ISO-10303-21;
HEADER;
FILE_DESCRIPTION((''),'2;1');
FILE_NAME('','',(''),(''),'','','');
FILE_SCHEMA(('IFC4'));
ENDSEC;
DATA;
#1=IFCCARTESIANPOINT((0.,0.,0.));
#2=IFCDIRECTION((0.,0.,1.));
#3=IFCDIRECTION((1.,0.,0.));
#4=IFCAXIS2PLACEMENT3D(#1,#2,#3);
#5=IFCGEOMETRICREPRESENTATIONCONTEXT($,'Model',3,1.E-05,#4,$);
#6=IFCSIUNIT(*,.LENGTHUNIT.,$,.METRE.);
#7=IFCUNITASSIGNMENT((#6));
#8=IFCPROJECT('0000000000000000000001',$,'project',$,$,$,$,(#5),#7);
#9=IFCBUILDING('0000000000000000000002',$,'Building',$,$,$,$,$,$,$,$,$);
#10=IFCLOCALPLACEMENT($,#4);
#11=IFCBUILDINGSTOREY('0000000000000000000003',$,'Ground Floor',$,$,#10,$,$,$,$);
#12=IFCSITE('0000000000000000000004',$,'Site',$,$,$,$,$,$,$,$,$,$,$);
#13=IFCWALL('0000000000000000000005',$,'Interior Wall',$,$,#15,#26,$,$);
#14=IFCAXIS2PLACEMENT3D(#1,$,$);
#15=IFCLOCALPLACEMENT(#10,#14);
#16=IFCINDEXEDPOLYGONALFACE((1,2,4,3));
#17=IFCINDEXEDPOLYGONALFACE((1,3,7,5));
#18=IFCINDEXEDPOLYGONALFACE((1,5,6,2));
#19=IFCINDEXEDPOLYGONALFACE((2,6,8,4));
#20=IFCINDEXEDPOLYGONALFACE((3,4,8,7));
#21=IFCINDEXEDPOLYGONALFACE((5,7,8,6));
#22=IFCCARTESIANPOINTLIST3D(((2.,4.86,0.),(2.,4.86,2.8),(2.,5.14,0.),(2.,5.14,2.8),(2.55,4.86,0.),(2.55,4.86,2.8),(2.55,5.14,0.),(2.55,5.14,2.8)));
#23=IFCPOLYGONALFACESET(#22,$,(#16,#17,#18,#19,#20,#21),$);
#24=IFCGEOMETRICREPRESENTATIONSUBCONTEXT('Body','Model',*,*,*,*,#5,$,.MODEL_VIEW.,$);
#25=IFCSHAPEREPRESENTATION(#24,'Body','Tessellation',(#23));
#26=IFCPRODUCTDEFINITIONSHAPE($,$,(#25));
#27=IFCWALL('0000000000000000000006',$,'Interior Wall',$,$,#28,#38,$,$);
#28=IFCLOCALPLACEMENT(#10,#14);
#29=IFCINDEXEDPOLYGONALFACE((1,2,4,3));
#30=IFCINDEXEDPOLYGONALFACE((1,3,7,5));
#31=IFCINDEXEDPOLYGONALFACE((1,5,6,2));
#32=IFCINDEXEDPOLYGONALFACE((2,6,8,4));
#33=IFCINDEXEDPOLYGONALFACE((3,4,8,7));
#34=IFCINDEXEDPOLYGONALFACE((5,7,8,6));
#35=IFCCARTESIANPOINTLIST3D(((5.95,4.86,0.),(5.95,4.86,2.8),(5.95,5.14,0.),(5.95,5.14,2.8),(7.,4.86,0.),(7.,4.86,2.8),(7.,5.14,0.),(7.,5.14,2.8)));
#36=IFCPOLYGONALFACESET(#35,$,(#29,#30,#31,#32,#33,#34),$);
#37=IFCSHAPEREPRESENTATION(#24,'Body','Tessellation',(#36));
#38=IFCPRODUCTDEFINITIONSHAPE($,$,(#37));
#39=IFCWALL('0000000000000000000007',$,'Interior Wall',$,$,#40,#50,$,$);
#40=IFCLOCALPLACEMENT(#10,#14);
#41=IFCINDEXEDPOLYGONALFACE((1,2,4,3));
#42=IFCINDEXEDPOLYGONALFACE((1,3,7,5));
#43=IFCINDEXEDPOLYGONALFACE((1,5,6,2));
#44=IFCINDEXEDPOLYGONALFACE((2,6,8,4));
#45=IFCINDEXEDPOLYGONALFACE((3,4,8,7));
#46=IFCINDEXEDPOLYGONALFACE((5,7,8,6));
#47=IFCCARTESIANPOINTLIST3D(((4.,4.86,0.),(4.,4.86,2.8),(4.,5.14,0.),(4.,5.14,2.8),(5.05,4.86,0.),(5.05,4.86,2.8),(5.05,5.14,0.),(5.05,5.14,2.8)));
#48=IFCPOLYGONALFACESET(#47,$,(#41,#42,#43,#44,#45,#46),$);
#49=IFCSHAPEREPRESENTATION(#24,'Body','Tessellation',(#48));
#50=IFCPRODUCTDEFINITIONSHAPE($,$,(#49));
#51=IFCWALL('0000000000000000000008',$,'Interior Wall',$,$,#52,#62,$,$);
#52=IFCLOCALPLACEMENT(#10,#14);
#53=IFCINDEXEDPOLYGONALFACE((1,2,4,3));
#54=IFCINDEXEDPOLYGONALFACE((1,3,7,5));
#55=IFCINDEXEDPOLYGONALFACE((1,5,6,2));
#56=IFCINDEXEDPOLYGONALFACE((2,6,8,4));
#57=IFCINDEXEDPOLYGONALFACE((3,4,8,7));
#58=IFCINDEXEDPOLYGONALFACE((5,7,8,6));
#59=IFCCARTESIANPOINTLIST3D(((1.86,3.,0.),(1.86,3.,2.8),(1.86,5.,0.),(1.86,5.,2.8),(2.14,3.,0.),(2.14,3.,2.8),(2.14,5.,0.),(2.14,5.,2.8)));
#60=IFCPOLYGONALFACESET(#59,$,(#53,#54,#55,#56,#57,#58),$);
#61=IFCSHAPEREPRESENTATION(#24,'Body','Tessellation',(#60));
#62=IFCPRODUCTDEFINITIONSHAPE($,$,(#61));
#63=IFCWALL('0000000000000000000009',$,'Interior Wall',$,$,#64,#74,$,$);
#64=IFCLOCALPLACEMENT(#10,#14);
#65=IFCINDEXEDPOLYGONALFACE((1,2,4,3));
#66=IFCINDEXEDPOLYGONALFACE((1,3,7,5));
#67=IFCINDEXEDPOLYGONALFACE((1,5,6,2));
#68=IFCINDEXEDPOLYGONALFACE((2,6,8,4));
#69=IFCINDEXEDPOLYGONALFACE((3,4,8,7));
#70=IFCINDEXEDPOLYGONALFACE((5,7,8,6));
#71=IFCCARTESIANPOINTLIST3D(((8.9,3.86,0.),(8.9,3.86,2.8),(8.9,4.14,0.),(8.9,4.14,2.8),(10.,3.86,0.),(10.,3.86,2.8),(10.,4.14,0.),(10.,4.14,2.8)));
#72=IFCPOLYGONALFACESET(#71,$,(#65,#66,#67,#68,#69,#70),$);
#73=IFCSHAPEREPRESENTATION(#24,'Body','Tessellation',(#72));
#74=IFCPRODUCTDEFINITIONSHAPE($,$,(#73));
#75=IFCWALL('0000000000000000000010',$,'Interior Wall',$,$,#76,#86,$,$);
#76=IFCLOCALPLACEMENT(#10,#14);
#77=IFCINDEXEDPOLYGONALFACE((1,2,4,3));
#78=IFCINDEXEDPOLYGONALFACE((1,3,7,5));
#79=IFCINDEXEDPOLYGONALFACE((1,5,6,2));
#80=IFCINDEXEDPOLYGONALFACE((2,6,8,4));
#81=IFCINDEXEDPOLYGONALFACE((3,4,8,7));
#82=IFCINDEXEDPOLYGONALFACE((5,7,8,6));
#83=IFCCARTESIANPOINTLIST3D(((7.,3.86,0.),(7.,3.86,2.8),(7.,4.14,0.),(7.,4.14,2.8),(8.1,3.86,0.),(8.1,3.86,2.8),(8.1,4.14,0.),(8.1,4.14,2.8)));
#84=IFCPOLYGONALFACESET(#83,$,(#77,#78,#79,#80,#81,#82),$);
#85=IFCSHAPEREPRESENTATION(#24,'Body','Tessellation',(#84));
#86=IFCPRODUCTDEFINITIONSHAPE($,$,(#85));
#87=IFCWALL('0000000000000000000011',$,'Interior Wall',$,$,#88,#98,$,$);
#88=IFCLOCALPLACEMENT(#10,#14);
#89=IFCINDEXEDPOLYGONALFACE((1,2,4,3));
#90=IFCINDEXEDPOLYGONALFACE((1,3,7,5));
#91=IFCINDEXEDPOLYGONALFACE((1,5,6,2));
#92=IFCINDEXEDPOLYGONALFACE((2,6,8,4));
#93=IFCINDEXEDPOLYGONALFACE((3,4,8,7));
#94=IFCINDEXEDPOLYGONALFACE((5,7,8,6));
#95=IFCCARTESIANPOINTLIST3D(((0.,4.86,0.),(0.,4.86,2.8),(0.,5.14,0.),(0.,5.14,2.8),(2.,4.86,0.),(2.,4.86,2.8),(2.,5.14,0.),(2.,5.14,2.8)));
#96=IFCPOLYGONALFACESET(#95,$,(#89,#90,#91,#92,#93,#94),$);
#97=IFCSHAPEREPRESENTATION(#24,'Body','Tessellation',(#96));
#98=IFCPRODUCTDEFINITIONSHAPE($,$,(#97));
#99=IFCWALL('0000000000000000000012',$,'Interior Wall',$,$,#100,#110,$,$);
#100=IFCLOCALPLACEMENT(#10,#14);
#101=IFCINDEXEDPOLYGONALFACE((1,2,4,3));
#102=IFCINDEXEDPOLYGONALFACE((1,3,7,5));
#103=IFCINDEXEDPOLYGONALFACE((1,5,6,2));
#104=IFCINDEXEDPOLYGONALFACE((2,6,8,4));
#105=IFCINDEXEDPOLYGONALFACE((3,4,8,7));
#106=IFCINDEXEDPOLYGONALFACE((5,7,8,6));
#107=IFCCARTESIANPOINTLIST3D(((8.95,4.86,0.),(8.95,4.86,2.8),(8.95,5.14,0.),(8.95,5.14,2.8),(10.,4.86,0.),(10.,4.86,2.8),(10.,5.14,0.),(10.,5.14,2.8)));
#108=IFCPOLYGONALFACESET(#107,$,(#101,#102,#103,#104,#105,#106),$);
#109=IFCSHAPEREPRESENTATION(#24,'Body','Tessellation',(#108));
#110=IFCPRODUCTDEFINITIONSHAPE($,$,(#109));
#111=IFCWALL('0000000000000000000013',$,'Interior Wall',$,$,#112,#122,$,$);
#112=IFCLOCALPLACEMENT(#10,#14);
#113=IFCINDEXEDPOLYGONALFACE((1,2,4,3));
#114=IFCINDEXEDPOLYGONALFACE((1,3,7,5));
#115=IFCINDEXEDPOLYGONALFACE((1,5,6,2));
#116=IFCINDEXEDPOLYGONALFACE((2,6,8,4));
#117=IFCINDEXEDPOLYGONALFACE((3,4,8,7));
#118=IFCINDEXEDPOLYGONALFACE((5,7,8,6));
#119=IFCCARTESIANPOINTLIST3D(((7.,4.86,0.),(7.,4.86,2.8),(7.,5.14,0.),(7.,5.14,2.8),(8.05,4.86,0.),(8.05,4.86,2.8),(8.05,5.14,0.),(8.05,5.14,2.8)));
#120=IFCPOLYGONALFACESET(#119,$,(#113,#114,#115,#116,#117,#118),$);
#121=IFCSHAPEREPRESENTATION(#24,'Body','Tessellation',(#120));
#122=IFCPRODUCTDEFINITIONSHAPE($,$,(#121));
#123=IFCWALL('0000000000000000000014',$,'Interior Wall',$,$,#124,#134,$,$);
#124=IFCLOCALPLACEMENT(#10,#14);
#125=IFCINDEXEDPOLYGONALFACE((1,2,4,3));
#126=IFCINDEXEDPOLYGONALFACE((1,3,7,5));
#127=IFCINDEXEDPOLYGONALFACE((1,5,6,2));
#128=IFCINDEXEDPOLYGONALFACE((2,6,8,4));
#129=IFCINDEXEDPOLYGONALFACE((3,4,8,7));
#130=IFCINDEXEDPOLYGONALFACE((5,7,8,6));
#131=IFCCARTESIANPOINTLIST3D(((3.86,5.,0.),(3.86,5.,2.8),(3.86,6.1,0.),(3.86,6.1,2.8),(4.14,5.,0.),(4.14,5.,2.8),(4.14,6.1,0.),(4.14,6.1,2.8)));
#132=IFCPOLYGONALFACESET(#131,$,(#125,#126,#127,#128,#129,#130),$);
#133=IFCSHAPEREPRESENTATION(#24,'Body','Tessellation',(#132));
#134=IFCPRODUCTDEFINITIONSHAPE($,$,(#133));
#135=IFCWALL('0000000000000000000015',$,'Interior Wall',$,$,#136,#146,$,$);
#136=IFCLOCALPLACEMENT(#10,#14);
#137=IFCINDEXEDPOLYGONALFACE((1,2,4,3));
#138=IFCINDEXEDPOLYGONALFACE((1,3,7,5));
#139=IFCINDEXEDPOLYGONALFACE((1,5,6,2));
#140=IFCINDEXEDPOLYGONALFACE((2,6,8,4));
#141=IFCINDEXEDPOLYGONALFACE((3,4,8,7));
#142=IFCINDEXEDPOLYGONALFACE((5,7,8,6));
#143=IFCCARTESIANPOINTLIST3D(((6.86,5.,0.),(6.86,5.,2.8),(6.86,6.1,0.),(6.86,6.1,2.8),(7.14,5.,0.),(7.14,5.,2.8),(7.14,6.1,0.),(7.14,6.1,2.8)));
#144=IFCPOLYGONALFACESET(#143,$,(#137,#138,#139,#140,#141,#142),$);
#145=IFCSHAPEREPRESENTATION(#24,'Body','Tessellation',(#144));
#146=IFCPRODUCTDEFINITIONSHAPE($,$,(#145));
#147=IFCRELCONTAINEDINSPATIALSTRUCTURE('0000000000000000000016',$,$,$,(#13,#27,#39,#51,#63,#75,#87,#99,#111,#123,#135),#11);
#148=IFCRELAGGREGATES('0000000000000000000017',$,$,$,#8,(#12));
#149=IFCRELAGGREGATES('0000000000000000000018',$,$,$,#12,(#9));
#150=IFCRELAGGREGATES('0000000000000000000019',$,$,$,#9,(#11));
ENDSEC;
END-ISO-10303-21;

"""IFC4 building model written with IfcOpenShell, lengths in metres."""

from ifc_helpers import new_model, si_unit, frame, origin_with_axes, place, context, subcontext, project, spatial, indexed_curve, outline, extrude, element, save


model = new_model("IFC4")

# Units and contexts
model_context = context("Model", 3, precision=1e-05, world=origin_with_axes())
body_context = subcontext(model_context, "Body", "Model", "MODEL_VIEW")
ifc_project = project(units=[si_unit("LENGTHUNIT", "METRE")], contexts=[model_context])

# Site, building, storey
site = spatial("IfcSite", under=ifc_project, Name="Site")
building = spatial("IfcBuilding", under=site, Name="Building")
storey_placement = place(None, origin_with_axes())
storey = spatial("IfcBuildingStorey", under=building, at=storey_placement, Name="Ground Floor")

# Walls
for number, where, z_axis, x_axis, name in (
    (1, (2.55, 5.0, 0.0), (0.0, 0.0, 1.0), (-1.0, 0.0, 0.0), "Interior Wall"),
):
    element("IfcWall", number, at=place(storey_placement, frame(where, z_axis=z_axis, x_axis=x_axis)), inside=storey, Name=name, context=body_context, shape_type="SweptSolid", body=[
        extrude(outline(indexed_curve([(0.0, 0.0), (0.0, 0.28), (0.55, 0.28), (0.55, 0.0), (0.0, 0.0)], self_intersect=False)), frame((0.0, -0.14, 0.0), z_axis=(0.0, 0.0, 1.0), x_axis=(1.0, 0.0, 0.0)), (0.0, 0.0, 1.0), 2.8),
    ])
for number, where, z_axis, x_axis, name in (
    (2, (7.0, 5.0, 0.0), (0.0, 0.0, 1.0), (-1.0, 0.0, 0.0), "Interior Wall"),
    (3, (5.05, 5.0, 0.0), (0.0, 0.0, 1.0), (-1.0, 0.0, 0.0), "Interior Wall"),
):
    element("IfcWall", number, at=place(storey_placement, frame(where, z_axis=z_axis, x_axis=x_axis)), inside=storey, Name=name, context=body_context, shape_type="SweptSolid", body=[
        extrude(outline(indexed_curve([(0.0, 0.0), (0.0, 0.28), (1.05, 0.28), (1.05, 0.0), (0.0, 0.0)], self_intersect=False)), frame((0.0, -0.14, 0.0), z_axis=(0.0, 0.0, 1.0), x_axis=(1.0, 0.0, 0.0)), (0.0, 0.0, 1.0), 2.8),
    ])
wall_1_placement = place(storey_placement, frame((2.0, 5.0, 0.0), z_axis=(0.0, 0.0, 1.0), x_axis=(0.0, -1.0, 0.0)))
element("IfcWall", 4, at=wall_1_placement, inside=storey, Name="Interior Wall", context=body_context, shape_type="SweptSolid", body=[
    extrude(outline(indexed_curve([(0.0, 0.0), (0.0, 0.28), (2.0, 0.28), (2.0, 0.0), (0.0, 0.0)], self_intersect=False)), frame((0.0, -0.14, 0.0), z_axis=(0.0, 0.0, 1.0), x_axis=(1.0, 0.0, 0.0)), (0.0, 0.0, 1.0), 2.8),
])
for number, where, z_axis, x_axis, name in (
    (5, (10.0, 4.0, 0.0), (0.0, 0.0, 1.0), (-1.0, 0.0, 0.0), "Interior Wall"),
    (6, (8.1, 4.0, 0.0), (0.0, 0.0, 1.0), (-1.0, 0.0, 0.0), "Interior Wall"),
):
    element("IfcWall", number, at=place(storey_placement, frame(where, z_axis=z_axis, x_axis=x_axis)), inside=storey, Name=name, context=body_context, shape_type="SweptSolid", body=[
        extrude(outline(indexed_curve([(0.0, 0.0), (0.0, 0.28), (1.1, 0.28), (1.1, 0.0), (0.0, 0.0)], self_intersect=False)), frame((0.0, -0.14, 0.0), z_axis=(0.0, 0.0, 1.0), x_axis=(1.0, 0.0, 0.0)), (0.0, 0.0, 1.0), 2.8),
    ])
wall_2_placement = place(storey_placement, frame((2.0, 5.0, 0.0), z_axis=(0.0, 0.0, 1.0), x_axis=(-1.0, 0.0, 0.0)))
element("IfcWall", 7, at=wall_2_placement, inside=storey, Name="Interior Wall", context=body_context, shape_type="SweptSolid", body=[
    extrude(outline(indexed_curve([(0.0, 0.0), (0.0, 0.28), (2.0, 0.28), (2.0, 0.0), (0.0, 0.0)], self_intersect=False)), frame((0.0, -0.14, 0.0), z_axis=(0.0, 0.0, 1.0), x_axis=(1.0, 0.0, 0.0)), (0.0, 0.0, 1.0), 2.8),
])
for number, where, z_axis, x_axis, name in (
    (8, (10.0, 5.0, 0.0), (0.0, 0.0, 1.0), (-1.0, 0.0, 0.0), "Interior Wall"),
    (9, (8.05, 5.0, 0.0), (0.0, 0.0, 1.0), (-1.0, 0.0, 0.0), "Interior Wall"),
):
    element("IfcWall", number, at=place(storey_placement, frame(where, z_axis=z_axis, x_axis=x_axis)), inside=storey, Name=name, context=body_context, shape_type="SweptSolid", body=[
        extrude(outline(indexed_curve([(0.0, 0.0), (0.0, 0.28), (1.05, 0.28), (1.05, 0.0), (0.0, 0.0)], self_intersect=False)), frame((0.0, -0.14, 0.0), z_axis=(0.0, 0.0, 1.0), x_axis=(1.0, 0.0, 0.0)), (0.0, 0.0, 1.0), 2.8),
    ])
for number, where, z_axis, x_axis, name in (
    (10, (4.0, 5.0, 0.0), (0.0, 0.0, 1.0), (0.0, 1.0, 0.0), "Interior Wall"),
    (11, (7.0, 5.0, 0.0), (0.0, 0.0, 1.0), (0.0, 1.0, 0.0), "Interior Wall"),
):
    element("IfcWall", number, at=place(storey_placement, frame(where, z_axis=z_axis, x_axis=x_axis)), inside=storey, Name=name, context=body_context, shape_type="SweptSolid", body=[
        extrude(outline(indexed_curve([(0.0, 0.0), (0.0, 0.28), (1.1, 0.28), (1.1, 0.0), (0.0, 0.0)], self_intersect=False)), frame((0.0, -0.14, 0.0), z_axis=(0.0, 0.0, 1.0), x_axis=(1.0, 0.0, 0.0)), (0.0, 0.0, 1.0), 2.8),
    ])

save(model, "model.ifc")
